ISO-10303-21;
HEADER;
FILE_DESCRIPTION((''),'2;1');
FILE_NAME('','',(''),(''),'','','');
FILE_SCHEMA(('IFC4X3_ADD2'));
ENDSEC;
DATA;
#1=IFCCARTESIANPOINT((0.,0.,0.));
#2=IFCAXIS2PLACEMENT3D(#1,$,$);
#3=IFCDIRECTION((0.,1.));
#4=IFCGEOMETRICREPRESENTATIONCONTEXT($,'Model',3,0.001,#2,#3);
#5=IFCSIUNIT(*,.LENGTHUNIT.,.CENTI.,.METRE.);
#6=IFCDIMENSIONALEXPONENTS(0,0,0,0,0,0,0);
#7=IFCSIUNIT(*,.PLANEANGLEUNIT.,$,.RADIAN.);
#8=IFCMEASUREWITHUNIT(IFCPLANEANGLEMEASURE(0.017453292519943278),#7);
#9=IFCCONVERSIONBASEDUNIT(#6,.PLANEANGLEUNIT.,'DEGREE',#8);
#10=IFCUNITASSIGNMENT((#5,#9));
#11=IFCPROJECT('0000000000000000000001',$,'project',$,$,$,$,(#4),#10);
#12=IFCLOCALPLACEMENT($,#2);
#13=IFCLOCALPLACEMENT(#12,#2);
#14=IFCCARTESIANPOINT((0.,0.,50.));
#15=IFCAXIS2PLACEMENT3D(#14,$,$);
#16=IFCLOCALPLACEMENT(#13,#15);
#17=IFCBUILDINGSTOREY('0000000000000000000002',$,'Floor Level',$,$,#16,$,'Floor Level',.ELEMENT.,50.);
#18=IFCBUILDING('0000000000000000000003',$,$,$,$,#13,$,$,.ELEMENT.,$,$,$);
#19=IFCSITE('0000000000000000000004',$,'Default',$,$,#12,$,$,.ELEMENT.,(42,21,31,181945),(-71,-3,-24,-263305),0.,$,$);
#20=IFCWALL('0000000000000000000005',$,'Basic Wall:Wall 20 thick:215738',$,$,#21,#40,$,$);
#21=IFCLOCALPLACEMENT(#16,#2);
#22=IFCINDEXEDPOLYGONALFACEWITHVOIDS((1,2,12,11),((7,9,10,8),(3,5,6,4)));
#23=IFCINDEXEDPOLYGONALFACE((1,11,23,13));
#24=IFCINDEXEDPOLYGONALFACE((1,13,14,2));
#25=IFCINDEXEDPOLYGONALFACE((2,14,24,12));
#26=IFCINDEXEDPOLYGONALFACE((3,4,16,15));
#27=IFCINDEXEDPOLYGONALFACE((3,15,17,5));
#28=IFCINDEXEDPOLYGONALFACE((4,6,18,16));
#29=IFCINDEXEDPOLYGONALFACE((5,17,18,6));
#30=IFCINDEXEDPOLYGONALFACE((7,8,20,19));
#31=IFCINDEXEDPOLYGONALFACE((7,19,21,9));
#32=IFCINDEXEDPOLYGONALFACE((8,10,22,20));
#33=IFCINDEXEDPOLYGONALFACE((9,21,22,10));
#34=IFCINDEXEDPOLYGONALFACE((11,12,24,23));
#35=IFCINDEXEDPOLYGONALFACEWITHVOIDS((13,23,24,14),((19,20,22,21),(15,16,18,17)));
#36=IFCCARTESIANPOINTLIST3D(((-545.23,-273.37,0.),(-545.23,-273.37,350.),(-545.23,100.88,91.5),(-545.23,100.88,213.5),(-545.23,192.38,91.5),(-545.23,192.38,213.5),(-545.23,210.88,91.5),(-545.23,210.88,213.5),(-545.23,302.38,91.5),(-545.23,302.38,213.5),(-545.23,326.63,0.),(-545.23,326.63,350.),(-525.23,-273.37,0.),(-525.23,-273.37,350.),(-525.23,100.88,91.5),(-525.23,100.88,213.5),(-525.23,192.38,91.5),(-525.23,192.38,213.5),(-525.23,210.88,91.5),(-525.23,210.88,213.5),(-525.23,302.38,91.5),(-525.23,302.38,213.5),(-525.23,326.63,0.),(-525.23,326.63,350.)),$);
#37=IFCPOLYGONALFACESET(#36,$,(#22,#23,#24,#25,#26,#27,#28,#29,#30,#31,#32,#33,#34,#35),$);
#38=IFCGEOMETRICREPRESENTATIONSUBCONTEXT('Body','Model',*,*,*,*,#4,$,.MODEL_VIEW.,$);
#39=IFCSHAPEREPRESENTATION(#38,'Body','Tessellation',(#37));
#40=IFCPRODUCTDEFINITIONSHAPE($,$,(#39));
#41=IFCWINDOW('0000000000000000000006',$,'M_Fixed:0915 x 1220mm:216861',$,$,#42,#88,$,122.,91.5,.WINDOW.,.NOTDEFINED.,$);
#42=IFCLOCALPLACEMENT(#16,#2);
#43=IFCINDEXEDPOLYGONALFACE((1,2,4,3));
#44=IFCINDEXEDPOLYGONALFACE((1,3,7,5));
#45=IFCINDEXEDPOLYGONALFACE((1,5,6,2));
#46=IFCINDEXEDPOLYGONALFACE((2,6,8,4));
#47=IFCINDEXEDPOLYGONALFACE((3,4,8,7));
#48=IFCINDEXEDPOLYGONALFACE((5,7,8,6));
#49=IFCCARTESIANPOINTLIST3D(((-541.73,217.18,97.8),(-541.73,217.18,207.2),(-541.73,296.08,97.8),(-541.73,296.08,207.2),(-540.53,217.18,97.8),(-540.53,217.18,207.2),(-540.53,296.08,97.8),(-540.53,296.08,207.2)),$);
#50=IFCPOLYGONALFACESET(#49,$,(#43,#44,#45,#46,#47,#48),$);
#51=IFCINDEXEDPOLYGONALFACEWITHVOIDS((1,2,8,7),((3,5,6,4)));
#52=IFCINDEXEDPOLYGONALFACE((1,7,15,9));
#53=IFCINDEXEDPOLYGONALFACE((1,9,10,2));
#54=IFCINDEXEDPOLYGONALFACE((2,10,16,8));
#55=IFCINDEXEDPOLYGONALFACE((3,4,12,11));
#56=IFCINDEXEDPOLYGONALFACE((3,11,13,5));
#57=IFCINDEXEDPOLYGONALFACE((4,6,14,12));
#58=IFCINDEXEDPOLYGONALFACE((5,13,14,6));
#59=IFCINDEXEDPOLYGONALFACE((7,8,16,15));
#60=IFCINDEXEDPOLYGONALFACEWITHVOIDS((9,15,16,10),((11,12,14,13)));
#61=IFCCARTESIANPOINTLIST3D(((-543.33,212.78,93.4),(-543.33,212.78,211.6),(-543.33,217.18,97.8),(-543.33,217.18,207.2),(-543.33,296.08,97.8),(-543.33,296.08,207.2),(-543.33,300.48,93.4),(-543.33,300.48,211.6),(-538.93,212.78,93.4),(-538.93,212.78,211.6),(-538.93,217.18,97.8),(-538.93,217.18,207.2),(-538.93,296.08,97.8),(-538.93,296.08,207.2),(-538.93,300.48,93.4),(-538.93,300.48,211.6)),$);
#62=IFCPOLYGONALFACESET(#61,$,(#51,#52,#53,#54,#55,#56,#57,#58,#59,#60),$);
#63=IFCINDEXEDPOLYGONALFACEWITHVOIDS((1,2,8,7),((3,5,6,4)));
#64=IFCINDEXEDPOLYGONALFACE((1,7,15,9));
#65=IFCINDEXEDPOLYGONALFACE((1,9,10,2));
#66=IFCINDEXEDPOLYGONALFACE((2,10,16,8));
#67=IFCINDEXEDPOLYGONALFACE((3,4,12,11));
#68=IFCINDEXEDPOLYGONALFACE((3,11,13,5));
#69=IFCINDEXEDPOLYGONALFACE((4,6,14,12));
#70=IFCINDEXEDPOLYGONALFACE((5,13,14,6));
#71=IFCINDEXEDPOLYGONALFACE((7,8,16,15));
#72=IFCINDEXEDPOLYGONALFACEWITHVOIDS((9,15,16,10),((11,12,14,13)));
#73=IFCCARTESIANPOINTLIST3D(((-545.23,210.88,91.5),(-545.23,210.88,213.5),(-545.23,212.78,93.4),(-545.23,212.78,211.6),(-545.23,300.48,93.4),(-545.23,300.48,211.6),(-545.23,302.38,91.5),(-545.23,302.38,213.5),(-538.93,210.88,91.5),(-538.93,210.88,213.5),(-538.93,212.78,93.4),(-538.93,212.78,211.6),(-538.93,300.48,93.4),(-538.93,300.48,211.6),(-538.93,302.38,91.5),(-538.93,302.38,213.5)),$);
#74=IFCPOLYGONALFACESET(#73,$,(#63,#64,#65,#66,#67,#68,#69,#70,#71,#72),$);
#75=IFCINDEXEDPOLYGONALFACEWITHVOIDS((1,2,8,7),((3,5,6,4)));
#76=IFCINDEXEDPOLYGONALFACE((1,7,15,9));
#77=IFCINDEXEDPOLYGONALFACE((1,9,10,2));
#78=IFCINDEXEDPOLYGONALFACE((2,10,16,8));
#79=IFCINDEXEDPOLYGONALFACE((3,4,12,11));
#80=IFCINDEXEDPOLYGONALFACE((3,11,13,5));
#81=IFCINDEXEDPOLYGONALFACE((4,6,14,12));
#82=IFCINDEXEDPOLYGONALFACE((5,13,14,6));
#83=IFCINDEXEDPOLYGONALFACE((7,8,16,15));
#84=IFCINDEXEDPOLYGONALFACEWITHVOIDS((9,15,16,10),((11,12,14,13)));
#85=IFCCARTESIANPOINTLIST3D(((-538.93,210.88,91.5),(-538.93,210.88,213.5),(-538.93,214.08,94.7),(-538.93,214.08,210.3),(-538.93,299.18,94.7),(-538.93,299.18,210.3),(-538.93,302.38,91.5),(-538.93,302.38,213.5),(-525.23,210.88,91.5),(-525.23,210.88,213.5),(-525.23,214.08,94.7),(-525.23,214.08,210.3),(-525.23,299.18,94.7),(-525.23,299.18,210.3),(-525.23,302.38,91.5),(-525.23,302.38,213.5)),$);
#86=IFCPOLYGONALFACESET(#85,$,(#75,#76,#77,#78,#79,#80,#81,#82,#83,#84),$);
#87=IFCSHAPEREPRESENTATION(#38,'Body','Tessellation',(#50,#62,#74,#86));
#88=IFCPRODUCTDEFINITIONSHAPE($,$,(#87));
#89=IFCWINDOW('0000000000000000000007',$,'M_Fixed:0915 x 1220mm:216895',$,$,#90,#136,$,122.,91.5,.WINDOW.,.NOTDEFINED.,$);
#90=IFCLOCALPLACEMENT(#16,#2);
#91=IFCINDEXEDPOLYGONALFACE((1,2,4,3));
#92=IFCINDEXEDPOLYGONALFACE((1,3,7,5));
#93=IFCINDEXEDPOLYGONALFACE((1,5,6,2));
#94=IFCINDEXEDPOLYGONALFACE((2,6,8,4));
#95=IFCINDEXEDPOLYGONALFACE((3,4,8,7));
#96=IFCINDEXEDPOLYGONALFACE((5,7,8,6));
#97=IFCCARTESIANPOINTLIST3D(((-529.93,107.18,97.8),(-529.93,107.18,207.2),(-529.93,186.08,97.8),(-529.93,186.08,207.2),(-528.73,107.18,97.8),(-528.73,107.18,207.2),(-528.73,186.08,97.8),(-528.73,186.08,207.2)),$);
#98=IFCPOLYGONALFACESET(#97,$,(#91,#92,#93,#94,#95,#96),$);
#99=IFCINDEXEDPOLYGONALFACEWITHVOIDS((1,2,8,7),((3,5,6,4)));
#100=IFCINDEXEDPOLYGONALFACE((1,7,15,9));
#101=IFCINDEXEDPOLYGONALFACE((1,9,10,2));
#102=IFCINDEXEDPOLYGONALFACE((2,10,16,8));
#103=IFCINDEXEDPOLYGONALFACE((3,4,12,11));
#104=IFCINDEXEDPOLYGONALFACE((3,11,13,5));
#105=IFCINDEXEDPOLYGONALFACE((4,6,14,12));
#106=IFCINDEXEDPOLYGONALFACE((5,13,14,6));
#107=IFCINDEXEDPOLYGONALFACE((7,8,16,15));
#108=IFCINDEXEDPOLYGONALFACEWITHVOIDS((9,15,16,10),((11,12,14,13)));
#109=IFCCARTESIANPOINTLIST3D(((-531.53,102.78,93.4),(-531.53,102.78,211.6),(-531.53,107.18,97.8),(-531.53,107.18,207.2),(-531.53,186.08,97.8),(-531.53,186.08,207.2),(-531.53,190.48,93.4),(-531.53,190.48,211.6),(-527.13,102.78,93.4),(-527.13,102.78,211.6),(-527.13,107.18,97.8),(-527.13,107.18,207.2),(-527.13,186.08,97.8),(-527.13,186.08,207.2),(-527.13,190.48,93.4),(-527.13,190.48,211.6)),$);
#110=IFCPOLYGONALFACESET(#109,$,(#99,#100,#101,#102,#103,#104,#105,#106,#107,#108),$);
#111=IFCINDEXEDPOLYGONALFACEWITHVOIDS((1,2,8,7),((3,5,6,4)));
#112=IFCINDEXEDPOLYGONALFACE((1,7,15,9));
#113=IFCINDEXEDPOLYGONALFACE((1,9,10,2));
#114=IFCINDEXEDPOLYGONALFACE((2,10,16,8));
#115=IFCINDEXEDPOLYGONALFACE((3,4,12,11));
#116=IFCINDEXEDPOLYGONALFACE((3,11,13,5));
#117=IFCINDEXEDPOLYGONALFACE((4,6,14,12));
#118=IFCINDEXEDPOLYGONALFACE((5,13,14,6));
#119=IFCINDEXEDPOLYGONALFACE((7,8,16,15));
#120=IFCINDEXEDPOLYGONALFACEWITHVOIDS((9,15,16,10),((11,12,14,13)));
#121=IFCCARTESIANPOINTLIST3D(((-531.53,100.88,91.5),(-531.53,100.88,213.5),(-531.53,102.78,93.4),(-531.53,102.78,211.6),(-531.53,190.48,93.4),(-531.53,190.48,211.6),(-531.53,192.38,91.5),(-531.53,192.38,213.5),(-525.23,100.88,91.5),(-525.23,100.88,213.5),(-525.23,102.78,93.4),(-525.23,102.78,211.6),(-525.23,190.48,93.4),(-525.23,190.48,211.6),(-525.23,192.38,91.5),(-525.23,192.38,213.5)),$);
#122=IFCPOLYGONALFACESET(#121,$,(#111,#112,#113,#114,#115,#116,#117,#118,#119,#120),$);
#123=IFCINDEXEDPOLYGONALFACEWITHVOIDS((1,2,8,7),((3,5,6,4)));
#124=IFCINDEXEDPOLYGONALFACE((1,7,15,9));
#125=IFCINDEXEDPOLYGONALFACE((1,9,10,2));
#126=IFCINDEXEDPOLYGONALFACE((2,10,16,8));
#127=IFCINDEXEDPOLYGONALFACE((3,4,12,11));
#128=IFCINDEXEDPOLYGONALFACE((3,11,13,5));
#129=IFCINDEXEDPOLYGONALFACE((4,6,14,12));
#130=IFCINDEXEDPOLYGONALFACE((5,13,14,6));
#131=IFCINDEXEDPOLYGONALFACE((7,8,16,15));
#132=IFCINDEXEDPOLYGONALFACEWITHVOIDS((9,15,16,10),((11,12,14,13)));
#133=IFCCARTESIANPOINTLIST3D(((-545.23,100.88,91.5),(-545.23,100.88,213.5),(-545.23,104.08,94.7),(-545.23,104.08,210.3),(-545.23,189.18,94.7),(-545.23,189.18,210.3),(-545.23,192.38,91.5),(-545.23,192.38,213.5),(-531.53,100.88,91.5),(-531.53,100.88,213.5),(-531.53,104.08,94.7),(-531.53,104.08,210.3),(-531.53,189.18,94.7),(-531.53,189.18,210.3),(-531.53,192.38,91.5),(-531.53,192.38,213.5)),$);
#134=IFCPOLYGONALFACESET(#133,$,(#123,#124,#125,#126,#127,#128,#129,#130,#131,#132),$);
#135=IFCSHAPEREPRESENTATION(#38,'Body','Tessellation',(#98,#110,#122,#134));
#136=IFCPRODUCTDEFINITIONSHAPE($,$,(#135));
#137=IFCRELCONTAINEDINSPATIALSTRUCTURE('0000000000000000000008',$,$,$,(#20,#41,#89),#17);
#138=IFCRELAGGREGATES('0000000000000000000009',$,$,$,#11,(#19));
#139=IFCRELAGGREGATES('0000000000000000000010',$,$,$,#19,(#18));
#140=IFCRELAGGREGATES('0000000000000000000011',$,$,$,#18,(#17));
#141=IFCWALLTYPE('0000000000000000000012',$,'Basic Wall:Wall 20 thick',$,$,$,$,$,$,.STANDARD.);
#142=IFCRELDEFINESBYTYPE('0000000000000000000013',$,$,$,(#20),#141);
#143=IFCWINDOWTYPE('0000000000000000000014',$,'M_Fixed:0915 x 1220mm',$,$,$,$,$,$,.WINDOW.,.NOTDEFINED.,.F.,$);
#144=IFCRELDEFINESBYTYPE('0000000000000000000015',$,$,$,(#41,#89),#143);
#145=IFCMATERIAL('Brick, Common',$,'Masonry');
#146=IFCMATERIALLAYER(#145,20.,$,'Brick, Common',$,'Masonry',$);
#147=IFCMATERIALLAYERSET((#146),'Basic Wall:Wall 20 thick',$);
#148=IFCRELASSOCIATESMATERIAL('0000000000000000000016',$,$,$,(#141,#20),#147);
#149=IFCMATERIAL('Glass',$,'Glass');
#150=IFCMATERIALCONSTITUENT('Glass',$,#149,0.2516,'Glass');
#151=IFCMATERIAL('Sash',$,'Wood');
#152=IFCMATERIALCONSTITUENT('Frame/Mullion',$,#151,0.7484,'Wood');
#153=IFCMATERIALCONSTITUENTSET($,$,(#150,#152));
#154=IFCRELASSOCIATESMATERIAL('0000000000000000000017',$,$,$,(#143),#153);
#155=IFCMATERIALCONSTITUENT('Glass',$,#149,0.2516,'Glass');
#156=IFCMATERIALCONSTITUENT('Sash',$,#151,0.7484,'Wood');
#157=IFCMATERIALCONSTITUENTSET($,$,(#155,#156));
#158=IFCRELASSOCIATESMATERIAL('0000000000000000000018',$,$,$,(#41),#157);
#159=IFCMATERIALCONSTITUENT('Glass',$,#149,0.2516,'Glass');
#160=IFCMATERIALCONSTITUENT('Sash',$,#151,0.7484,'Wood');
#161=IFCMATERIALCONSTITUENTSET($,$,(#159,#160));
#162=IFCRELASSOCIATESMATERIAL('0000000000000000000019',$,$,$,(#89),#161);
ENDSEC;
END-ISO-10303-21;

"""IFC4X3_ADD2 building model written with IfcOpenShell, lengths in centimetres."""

from ifc_helpers import new_model, entity, si_unit, converted_unit, direction, frame, frame_2d, origin, place, context, subcontext, project, spatial, polyline, rectangle, outline, extrude, source, transform, mapped, material, layer, layer_set, constituent, constituent_set, type_object, type_shapes, element, fill, save


model = new_model("IFC4X3_ADD2")

# Units and contexts
model_context = context("Model", 3, precision=0.001, world=origin(), true_north=direction((0.0, 1.0)))
body_context = subcontext(model_context, "Body", "Model", "MODEL_VIEW")
ifc_project = project(units=[si_unit("LENGTHUNIT", "METRE", prefix="CENTI"), converted_unit("PLANEANGLEUNIT", "DEGREE", entity("IfcPlaneAngleMeasure", 0.017453292519943278), si_unit("PLANEANGLEUNIT", "RADIAN"), dimensions=[0, 0, 0, 0, 0, 0, 0])], contexts=[model_context])

# Site, building, storey
site_placement = place(None, origin())
site = spatial("IfcSite", under=ifc_project, at=site_placement, Name="Default", CompositionType="ELEMENT", RefLatitude=(42, 21, 31, 181945), RefLongitude=(-71, -3, -24, -263305), RefElevation=0.0)
building_placement = place(site_placement, origin())
building = spatial("IfcBuilding", under=site, at=building_placement, CompositionType="ELEMENT")
storey_placement = place(building_placement, frame((0.0, 0.0, 50.0)))
storey = spatial("IfcBuildingStorey", under=building, at=storey_placement, Name="Floor Level", LongName="Floor Level", CompositionType="ELEMENT", Elevation=50.0)

# Shared definitions
ifc_material_1 = material(Name="Brick, Common", Category="Masonry")
ifc_layer = layer(ifc_material_1, 20.0, Name="Brick, Common", Category="Masonry")
ifc_layer_set = layer_set([ifc_layer], Name="Basic Wall:Wall 20 thick")
wall_type = type_object("IfcWallType", Name="Basic Wall:Wall 20 thick", PredefinedType="STANDARD", material=ifc_layer_set)
ifc_material_2 = material(Name="Glass", Category="Glass")
ifc_material_3 = material(Name="Sash", Category="Wood")
ifc_constituent_1 = constituent(ifc_material_2, Name="Glass", Category="Glass", fraction=0.2516)
ifc_constituent_2 = constituent(ifc_material_3, Name="Frame/Mullion", Category="Wood", fraction=0.7484)
ifc_constituent_set_1 = constituent_set(constituents=[ifc_constituent_1, ifc_constituent_2])
window_type = type_object("IfcWindowType", Name="M_Fixed:0915 x 1220mm", ParameterTakesPrecedence=False, PartitioningType="NOTDEFINED", PredefinedType="WINDOW", material=ifc_constituent_set_1)
shared_shape_1 = source(origin(), body_context, "Body", "SweptSolid", [
    extrude(rectangle(XDim=1.2, YDim=78.9, at=frame_2d((0.0, 0.0), x_axis=(1.0, 0.0))), frame((45.75, 15.9, 6.3), z_axis=(0.0, 0.0, 1.0), x_axis=(0.0, -1.0, 0.0)), (0.0, 0.0, 1.0), 109.4),
    extrude(outline(polyline([(-43.85, -59.1), (43.85, -59.1), (43.85, 59.1), (-43.85, 59.1), (-43.85, -59.1)]), holes=[polyline([(-39.45, -54.7), (-39.45, 54.7), (39.45, 54.7), (39.45, -54.7), (-39.45, -54.7)])]), frame((45.75, 13.7, 61.0), z_axis=(0.0, 1.0, 0.0), x_axis=(1.0, 0.0, 0.0)), (0.0, 0.0, 1.0), 4.4),
    extrude(outline(polyline([(-45.75, -61.0), (45.75, -61.0), (45.75, 61.0), (-45.75, 61.0), (-45.75, -61.0)]), holes=[polyline([(-43.85, -59.1), (-43.85, 59.1), (43.85, 59.1), (43.85, -59.1), (-43.85, -59.1)])]), frame((45.75, 13.7, 61.0), z_axis=(0.0, 1.0, 0.0), x_axis=(1.0, 0.0, 0.0)), (0.0, 0.0, 1.0), 6.3),
    extrude(outline(polyline([(-45.75, -61.0), (45.75, -61.0), (45.75, 61.0), (-45.75, 61.0), (-45.75, -61.0)]), holes=[polyline([(-42.55, -57.8), (-42.55, 57.8), (42.55, 57.8), (42.55, -57.8), (-42.55, -57.8)])]), frame((45.75, 0.0, 61.0), z_axis=(0.0, 1.0, 0.0), x_axis=(1.0, 0.0, 0.0)), (0.0, 0.0, 1.0), 13.7),
])
type_shapes(window_type, [shared_shape_1])

# Wall, openings, windows
wall_1_placement = place(storey_placement, frame((-535.23, 326.63, 0.0), z_axis=(0.0, 0.0, 1.0), x_axis=(0.0, -1.0, 0.0)))
wall_1 = element("IfcWall", 1, at=wall_1_placement, inside=storey, type_object=wall_type, material=ifc_layer_set, Name="Basic Wall:Wall 20 thick:215738", context=body_context, shape_type="SweptSolid", body=[
    extrude(rectangle(XDim=600.0, YDim=20.0, at=frame_2d((300.0, 0.0), x_axis=(-1.0, 0.0))), origin(), (0.0, 0.0, 1.0), 350.0),
])
opening_1_placement = place(wall_1_placement, frame((115.75, 10.0, 91.5)))
opening_1 = element("IfcOpeningElement", 2, at=opening_1_placement, cuts=wall_1, PredefinedType="OPENING", context=body_context, shape_type="SweptSolid", body=[
    extrude(rectangle(XDim=122.0, YDim=91.5, at=frame_2d((61.0, 45.75), x_axis=(1.0, 0.0))), frame((0.0, 0.0, 0.0), z_axis=(0.0, -1.0, 0.0), x_axis=(0.0, 0.0, 1.0)), (0.0, 0.0, 1.0), 20.0),
])
opening_2_placement = place(wall_1_placement, frame((134.25, -10.0, 91.5)))
opening_2 = element("IfcOpeningElement", 3, at=opening_2_placement, cuts=wall_1, PredefinedType="OPENING", context=body_context, shape_type="SweptSolid", body=[
    extrude(rectangle(XDim=122.0, YDim=91.5, at=frame_2d((61.0, 45.75), x_axis=(1.0, 0.0))), frame((0.0, 0.0, 0.0), z_axis=(0.0, 1.0, 0.0), x_axis=(0.0, 0.0, 1.0)), (0.0, 0.0, 1.0), 20.0),
])
ifc_constituent_3 = constituent(ifc_material_2, Name="Glass", Category="Glass", fraction=0.2516)
ifc_constituent_4 = constituent(ifc_material_3, Name="Sash", Category="Wood", fraction=0.7484)
ifc_constituent_set_2 = constituent_set(constituents=[ifc_constituent_3, ifc_constituent_4])
window_1_placement = place(opening_1_placement, frame((0.0, 0.0, 0.0), z_axis=(0.0, 0.0, 1.0), x_axis=(-1.0, 0.0, 0.0)))
window_1 = element("IfcWindow", 4, at=window_1_placement, inside=storey, type_object=window_type, material=ifc_constituent_set_2, Name="M_Fixed:0915 x 1220mm:216861", OverallHeight=122.0, OverallWidth=91.5, PartitioningType="NOTDEFINED", PredefinedType="WINDOW", context=body_context, shape_type="MappedRepresentation", body=[
    mapped(shared_shape_1, transform((0.0, 0.0, 0.0), scale=1.0)),
])
fill(opening_1, window_1)
ifc_constituent_5 = constituent(ifc_material_2, Name="Glass", Category="Glass", fraction=0.2516)
ifc_constituent_6 = constituent(ifc_material_3, Name="Sash", Category="Wood", fraction=0.7484)
ifc_constituent_set_3 = constituent_set(constituents=[ifc_constituent_5, ifc_constituent_6])
window_2_placement = place(opening_2_placement, origin())
window_2 = element("IfcWindow", 5, at=window_2_placement, inside=storey, type_object=window_type, material=ifc_constituent_set_3, Name="M_Fixed:0915 x 1220mm:216895", OverallHeight=122.0, OverallWidth=91.5, PartitioningType="NOTDEFINED", PredefinedType="WINDOW", context=body_context, shape_type="MappedRepresentation", body=[
    mapped(shared_shape_1, transform((0.0, 0.0, 0.0), scale=1.0)),
])
fill(opening_2, window_2)

save(model, "model.ifc")
